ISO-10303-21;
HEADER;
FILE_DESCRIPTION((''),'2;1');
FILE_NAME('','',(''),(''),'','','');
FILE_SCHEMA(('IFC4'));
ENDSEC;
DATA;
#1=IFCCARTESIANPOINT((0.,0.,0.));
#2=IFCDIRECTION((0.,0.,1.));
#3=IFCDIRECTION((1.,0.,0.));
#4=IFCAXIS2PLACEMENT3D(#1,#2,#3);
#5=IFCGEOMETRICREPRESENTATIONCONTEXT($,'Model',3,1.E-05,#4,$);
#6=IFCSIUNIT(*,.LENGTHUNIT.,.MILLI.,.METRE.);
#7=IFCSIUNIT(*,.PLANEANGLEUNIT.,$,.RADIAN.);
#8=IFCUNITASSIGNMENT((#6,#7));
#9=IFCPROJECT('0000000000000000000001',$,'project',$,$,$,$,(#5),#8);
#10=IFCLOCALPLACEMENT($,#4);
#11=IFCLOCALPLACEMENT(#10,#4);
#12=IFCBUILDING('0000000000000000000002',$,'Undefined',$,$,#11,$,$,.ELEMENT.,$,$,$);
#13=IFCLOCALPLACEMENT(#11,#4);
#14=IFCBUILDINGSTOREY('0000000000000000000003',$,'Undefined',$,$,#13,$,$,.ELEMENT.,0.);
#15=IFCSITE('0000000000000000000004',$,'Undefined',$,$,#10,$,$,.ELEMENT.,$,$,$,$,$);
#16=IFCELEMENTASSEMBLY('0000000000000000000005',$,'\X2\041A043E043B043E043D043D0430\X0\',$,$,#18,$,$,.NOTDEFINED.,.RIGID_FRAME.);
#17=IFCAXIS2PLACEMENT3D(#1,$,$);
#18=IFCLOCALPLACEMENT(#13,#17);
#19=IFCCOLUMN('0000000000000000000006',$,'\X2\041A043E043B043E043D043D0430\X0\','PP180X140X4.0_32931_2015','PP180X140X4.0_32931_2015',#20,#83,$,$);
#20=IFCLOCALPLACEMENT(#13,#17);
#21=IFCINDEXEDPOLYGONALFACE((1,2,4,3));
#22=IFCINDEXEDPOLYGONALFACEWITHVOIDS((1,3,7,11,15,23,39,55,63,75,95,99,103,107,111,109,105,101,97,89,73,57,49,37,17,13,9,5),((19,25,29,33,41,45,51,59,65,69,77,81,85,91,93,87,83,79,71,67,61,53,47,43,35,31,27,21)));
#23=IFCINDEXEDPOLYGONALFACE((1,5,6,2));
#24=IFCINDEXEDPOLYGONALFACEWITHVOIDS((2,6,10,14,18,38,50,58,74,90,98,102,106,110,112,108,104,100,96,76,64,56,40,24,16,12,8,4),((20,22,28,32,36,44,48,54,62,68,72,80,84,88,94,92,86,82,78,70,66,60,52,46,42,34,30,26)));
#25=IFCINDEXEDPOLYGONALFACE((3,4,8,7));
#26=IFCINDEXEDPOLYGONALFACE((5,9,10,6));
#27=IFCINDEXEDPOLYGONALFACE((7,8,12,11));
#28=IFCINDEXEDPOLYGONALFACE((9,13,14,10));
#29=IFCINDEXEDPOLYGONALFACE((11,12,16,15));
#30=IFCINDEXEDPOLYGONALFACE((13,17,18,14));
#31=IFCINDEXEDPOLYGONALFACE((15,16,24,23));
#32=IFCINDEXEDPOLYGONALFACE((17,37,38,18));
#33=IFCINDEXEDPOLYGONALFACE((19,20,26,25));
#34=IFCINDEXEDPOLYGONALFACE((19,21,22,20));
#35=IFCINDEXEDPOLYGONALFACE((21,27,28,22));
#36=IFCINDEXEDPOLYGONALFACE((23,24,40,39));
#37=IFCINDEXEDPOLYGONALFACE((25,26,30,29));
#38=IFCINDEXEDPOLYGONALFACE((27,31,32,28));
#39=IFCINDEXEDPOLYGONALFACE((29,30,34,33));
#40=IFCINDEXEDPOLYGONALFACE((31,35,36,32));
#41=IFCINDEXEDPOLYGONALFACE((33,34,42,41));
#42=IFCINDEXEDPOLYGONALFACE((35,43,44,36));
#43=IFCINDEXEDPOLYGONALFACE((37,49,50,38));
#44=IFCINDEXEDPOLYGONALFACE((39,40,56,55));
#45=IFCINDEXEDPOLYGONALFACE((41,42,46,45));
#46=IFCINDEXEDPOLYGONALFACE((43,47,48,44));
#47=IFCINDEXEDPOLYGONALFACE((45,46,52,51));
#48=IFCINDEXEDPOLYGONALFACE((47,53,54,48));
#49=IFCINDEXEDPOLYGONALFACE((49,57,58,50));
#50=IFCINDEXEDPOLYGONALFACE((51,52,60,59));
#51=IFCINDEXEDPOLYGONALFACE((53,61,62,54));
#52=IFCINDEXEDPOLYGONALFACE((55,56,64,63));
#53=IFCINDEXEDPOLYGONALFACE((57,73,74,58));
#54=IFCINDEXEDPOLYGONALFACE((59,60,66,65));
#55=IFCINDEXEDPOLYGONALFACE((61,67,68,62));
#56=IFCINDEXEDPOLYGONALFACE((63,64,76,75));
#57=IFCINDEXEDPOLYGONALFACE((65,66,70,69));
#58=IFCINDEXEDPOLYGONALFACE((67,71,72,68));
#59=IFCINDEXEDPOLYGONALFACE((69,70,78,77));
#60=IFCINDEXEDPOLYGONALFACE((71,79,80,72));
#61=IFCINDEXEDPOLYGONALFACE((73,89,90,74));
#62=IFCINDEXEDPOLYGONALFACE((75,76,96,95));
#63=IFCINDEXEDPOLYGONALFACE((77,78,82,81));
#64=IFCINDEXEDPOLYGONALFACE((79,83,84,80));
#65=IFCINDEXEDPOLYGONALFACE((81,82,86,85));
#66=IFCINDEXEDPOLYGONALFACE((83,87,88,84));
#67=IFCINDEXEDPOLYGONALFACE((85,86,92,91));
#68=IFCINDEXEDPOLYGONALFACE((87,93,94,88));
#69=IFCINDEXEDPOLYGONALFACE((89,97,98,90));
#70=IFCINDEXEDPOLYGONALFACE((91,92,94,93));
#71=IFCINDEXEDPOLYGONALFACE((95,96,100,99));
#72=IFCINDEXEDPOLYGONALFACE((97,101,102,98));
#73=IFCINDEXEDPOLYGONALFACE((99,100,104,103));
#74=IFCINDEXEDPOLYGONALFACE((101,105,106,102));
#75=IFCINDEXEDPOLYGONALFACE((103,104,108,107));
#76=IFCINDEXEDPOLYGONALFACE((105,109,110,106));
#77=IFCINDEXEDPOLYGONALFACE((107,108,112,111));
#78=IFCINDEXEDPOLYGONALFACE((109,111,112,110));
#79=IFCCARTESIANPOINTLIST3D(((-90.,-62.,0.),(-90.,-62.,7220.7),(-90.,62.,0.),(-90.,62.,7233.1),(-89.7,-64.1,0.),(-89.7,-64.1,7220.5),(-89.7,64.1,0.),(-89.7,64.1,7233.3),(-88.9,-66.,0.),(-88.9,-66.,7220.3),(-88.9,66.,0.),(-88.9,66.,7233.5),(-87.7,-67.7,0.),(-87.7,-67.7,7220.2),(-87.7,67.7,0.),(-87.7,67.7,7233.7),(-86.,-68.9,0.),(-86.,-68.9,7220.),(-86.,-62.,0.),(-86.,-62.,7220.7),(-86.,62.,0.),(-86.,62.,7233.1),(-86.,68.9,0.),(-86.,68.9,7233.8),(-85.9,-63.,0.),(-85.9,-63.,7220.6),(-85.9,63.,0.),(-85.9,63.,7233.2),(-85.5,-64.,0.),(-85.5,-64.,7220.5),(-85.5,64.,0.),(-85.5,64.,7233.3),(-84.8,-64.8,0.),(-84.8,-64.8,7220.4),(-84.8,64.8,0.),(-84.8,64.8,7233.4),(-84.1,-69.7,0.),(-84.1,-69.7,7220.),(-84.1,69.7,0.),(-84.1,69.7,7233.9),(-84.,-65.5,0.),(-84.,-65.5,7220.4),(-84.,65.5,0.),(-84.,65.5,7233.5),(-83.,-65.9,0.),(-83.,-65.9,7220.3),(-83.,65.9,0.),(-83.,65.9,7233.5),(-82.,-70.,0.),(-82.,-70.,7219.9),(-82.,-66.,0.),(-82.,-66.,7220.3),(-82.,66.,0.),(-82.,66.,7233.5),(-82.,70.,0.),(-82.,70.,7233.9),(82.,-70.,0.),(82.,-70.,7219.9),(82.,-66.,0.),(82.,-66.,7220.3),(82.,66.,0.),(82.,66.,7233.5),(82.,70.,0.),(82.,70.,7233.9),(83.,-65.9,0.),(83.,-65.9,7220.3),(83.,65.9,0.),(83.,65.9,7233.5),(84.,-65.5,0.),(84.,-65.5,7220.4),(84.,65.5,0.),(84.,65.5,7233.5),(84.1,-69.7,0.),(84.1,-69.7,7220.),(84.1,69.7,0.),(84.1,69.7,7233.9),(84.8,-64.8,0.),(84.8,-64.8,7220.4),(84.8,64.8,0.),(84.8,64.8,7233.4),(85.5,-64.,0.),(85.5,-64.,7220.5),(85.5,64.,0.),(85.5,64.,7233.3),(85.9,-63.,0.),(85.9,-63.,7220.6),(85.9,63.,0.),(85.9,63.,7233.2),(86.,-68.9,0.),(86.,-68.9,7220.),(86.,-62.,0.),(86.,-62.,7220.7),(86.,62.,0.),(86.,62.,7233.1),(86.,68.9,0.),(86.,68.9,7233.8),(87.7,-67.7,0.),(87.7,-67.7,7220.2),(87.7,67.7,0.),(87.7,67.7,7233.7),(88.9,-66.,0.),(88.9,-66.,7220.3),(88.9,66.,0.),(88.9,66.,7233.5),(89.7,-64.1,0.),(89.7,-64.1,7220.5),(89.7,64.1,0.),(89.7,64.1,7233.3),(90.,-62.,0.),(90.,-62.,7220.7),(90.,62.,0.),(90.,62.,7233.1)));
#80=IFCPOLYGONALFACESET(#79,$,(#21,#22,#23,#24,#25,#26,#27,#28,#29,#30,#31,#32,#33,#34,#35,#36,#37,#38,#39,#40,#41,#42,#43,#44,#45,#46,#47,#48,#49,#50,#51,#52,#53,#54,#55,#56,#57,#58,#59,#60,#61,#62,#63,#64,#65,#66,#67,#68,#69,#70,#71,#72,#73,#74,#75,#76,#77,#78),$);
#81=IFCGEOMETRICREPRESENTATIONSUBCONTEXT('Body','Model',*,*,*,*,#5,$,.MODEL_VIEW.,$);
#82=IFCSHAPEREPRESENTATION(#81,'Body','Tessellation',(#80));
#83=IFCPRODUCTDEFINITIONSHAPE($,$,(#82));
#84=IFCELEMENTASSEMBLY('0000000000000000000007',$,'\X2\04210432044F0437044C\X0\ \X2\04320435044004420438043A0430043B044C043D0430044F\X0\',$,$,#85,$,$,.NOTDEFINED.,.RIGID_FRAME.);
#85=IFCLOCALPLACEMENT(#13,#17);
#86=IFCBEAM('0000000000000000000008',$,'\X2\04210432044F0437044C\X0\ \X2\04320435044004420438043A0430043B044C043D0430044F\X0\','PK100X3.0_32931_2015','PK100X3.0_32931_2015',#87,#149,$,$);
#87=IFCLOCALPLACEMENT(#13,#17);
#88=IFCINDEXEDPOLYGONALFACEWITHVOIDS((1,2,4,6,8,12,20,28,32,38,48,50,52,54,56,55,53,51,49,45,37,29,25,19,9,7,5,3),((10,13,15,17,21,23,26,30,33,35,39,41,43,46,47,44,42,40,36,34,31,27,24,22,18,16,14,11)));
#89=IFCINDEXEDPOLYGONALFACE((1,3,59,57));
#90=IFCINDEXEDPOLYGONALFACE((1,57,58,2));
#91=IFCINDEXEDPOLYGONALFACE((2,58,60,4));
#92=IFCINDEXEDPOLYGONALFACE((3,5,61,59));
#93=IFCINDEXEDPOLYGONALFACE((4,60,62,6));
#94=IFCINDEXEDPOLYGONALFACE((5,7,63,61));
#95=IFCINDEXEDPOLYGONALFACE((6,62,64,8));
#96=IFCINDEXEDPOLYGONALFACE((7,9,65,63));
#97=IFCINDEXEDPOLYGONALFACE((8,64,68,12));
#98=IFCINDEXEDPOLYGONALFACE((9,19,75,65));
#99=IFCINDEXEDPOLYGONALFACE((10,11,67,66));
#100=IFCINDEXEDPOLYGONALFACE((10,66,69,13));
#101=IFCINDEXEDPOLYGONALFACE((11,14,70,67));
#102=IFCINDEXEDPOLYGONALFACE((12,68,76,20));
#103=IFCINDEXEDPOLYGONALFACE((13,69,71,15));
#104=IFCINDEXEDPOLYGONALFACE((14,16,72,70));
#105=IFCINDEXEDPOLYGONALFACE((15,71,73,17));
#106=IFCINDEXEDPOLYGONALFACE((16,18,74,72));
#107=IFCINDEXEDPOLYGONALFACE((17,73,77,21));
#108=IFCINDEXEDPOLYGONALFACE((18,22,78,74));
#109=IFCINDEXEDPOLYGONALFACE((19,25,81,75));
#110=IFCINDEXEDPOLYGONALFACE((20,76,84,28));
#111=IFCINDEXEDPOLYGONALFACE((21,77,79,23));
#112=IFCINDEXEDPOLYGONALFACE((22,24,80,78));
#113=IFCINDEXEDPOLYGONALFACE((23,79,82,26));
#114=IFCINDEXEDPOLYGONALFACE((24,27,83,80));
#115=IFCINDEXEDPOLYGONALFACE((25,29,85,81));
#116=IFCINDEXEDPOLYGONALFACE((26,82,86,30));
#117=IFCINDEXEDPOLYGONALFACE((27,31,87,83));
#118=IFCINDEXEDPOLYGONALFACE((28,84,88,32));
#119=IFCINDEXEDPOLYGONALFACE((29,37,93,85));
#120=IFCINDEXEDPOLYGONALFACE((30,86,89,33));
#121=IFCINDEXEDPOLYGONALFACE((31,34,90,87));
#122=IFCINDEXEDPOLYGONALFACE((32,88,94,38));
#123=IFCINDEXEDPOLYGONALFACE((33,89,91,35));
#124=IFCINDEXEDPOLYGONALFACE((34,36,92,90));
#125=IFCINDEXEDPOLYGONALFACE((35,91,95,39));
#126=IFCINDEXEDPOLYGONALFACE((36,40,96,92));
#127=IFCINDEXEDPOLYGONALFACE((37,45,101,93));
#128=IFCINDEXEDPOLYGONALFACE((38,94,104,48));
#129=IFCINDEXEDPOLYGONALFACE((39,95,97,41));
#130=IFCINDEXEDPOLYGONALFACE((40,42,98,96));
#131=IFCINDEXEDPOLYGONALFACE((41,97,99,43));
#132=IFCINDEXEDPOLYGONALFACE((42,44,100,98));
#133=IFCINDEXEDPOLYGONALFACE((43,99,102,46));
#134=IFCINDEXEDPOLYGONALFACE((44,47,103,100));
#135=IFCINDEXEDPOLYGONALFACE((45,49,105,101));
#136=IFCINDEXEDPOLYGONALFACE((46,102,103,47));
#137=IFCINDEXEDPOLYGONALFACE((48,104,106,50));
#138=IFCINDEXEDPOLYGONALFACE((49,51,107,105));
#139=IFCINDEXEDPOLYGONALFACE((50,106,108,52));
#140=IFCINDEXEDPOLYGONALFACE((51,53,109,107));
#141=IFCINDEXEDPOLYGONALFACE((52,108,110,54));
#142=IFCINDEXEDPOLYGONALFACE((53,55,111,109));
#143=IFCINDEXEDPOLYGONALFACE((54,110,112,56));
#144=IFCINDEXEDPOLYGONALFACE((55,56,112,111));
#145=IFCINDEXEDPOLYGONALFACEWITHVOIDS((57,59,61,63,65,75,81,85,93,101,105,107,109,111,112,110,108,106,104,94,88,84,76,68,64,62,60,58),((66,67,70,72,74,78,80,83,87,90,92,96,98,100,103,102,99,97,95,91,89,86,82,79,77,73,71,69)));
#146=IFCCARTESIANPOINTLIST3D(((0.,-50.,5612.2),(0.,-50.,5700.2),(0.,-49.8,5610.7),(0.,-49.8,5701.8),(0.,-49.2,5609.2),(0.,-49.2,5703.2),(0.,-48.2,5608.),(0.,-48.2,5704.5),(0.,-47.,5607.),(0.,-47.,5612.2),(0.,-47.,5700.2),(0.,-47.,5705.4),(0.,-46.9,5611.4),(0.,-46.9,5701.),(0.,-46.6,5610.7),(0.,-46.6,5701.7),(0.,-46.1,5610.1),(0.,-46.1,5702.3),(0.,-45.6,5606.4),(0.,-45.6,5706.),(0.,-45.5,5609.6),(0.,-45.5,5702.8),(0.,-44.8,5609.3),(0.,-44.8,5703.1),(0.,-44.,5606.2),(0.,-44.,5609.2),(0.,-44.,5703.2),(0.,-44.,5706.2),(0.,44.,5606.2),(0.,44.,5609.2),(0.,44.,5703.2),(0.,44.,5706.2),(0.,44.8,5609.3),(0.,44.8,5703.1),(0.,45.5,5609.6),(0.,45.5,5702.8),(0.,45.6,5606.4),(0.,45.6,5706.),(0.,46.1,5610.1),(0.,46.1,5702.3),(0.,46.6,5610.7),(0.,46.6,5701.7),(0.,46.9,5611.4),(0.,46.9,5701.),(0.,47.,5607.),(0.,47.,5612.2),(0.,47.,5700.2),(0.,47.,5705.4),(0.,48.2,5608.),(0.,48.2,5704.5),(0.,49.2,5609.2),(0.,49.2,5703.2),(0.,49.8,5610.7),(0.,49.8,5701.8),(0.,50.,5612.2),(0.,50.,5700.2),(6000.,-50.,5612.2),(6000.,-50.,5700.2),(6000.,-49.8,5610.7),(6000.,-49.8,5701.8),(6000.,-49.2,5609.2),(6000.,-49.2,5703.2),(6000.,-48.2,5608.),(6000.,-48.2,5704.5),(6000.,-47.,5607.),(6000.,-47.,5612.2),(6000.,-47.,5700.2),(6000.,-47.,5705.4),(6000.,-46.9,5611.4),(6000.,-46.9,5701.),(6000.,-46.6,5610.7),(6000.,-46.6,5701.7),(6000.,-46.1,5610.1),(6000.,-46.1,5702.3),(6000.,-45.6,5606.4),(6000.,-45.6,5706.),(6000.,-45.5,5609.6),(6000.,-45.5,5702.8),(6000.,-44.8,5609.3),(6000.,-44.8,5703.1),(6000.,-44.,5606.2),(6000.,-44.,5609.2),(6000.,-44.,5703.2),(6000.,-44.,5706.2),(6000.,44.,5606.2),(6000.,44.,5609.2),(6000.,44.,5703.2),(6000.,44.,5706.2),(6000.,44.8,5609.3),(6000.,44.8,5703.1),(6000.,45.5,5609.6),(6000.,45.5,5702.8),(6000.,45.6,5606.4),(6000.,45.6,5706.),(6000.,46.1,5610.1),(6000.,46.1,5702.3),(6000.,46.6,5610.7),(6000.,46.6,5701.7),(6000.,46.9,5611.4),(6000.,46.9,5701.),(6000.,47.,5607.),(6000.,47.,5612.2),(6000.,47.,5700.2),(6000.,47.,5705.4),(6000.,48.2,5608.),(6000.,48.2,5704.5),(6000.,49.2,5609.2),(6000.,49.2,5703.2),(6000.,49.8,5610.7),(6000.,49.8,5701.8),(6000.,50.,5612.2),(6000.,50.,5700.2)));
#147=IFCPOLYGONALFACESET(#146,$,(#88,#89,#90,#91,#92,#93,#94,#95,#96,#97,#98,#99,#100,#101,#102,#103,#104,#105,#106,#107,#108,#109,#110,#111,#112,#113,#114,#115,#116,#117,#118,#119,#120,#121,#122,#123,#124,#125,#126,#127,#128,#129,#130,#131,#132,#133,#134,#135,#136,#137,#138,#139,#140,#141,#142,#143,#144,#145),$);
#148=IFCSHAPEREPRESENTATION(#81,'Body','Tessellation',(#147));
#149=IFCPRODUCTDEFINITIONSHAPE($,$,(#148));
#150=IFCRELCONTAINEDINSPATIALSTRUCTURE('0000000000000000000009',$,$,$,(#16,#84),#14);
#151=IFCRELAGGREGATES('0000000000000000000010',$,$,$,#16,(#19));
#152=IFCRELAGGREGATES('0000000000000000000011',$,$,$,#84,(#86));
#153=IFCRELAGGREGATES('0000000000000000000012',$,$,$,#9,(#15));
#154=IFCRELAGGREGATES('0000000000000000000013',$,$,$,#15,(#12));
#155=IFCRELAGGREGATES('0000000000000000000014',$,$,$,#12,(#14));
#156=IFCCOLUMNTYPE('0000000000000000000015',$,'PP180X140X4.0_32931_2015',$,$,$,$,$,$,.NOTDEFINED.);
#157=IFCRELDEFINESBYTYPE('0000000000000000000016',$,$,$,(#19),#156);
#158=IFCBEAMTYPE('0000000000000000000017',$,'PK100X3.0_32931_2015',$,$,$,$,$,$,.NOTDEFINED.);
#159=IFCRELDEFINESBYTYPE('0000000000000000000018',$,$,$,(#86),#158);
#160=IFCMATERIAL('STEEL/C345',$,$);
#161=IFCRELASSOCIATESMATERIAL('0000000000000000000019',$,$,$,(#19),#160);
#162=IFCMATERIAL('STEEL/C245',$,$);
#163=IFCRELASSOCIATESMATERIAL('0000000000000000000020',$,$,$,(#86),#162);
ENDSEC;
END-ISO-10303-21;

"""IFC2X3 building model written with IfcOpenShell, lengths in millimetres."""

from ifc_helpers import new_model, si_unit, frame, origin_with_axes, origin_2d_with_axis, place, context, subcontext, project, spatial, hollow_rectangle, extrude, clip, halfspace, material, type_object, element, aggregate, save


model = new_model("IFC2X3")

# Units and contexts
model_context = context("Model", 3, precision=1e-05, world=origin_with_axes())
body_context = subcontext(model_context, "Body", "Model", "MODEL_VIEW")
ifc_project = project(units=[si_unit("LENGTHUNIT", "METRE", prefix="MILLI"), si_unit("PLANEANGLEUNIT", "RADIAN")], contexts=[model_context])

# Site, building, storey
site_placement = place(None, origin_with_axes())
site = spatial("IfcSite", under=ifc_project, at=site_placement, Name="Undefined", CompositionType="ELEMENT")
building_placement = place(site_placement, origin_with_axes())
building = spatial("IfcBuilding", under=site, at=building_placement, Name="Undefined", CompositionType="ELEMENT")
storey_placement = place(building_placement, origin_with_axes())
storey = spatial("IfcBuildingStorey", under=building, at=storey_placement, Name="Undefined", CompositionType="ELEMENT", Elevation=0.0)

# Element assembly, column
assembly_1_placement = place(storey_placement, origin_with_axes())
assembly_1 = element("IfcElementAssembly", 1, at=assembly_1_placement, inside=storey, Name="Колонна", AssemblyPlace="NOTDEFINED", PredefinedType="RIGID_FRAME")
ifc_material_1 = material(Name="STEEL/C345")
column_type = type_object("IfcColumnType", Name="PP180X140X4.0_32931_2015", PredefinedType="NOTDEFINED")
column_placement = place(assembly_1_placement, frame((0.0, 0.0, 0.0), z_axis=(0.0, 0.0, 1.0), x_axis=(-1.0, 0.0, 0.0)))
column = element("IfcColumn", 2, at=column_placement, type_object=column_type, material=ifc_material_1, Name="Колонна", Description="PP180X140X4.0_32931_2015", ObjectType="PP180X140X4.0_32931_2015", context=body_context, shape_type="Clipping", body=[
    clip(extrude(hollow_rectangle(XDim=140.0, YDim=180.0, WallThickness=4.0, InnerFilletRadius=4.0, OuterFilletRadius=8.0, at=origin_2d_with_axis()), frame((0.0, 0.0, 7234.0), z_axis=(0.0, 0.0, -1.0), x_axis=(0.0, 1.0, 0.0)), (0.0, 0.0, 1.0), 7234.0), halfspace(frame((0.0, -142.2, 7241.2), z_axis=(0.0, 0.099504, 0.995037), x_axis=(0.0, -0.995037, 0.099504)), False)),
])
aggregate(assembly_1, [column])

# Element assembly, beam
assembly_2_placement = place(storey_placement, origin_with_axes())
assembly_2 = element("IfcElementAssembly", 3, at=assembly_2_placement, inside=storey, Name="Связь вертикальная", AssemblyPlace="NOTDEFINED", PredefinedType="RIGID_FRAME")
ifc_material_2 = material(Name="STEEL/C245")
beam_type_1 = type_object("IfcBeamType", Name="PK100X3.0_32931_2015", PredefinedType="NOTDEFINED")
beam_1_placement = place(assembly_2_placement, frame((0.0, 0.0, 5656.2), z_axis=(0.0, 0.0, 1.0), x_axis=(1.0, 0.0, 0.0)))
beam_1 = element("IfcBeam", 4, at=beam_1_placement, type_object=beam_type_1, material=ifc_material_2, Name="Связь вертикальная", Description="PK100X3.0_32931_2015", ObjectType="PK100X3.0_32931_2015", context=body_context, shape_type="SweptSolid", body=[
    extrude(hollow_rectangle(XDim=100.0, YDim=100.0, WallThickness=3.0, InnerFilletRadius=3.0, OuterFilletRadius=6.0, at=origin_2d_with_axis()), frame((6000.0, 0.0, 0.0), z_axis=(-1.0, 0.0, 0.0), x_axis=(0.0, -1.0, 0.0)), (0.0, 0.0, 1.0), 6000.0),
])
aggregate(assembly_2, [beam_1])

save(model, "model.ifc")
